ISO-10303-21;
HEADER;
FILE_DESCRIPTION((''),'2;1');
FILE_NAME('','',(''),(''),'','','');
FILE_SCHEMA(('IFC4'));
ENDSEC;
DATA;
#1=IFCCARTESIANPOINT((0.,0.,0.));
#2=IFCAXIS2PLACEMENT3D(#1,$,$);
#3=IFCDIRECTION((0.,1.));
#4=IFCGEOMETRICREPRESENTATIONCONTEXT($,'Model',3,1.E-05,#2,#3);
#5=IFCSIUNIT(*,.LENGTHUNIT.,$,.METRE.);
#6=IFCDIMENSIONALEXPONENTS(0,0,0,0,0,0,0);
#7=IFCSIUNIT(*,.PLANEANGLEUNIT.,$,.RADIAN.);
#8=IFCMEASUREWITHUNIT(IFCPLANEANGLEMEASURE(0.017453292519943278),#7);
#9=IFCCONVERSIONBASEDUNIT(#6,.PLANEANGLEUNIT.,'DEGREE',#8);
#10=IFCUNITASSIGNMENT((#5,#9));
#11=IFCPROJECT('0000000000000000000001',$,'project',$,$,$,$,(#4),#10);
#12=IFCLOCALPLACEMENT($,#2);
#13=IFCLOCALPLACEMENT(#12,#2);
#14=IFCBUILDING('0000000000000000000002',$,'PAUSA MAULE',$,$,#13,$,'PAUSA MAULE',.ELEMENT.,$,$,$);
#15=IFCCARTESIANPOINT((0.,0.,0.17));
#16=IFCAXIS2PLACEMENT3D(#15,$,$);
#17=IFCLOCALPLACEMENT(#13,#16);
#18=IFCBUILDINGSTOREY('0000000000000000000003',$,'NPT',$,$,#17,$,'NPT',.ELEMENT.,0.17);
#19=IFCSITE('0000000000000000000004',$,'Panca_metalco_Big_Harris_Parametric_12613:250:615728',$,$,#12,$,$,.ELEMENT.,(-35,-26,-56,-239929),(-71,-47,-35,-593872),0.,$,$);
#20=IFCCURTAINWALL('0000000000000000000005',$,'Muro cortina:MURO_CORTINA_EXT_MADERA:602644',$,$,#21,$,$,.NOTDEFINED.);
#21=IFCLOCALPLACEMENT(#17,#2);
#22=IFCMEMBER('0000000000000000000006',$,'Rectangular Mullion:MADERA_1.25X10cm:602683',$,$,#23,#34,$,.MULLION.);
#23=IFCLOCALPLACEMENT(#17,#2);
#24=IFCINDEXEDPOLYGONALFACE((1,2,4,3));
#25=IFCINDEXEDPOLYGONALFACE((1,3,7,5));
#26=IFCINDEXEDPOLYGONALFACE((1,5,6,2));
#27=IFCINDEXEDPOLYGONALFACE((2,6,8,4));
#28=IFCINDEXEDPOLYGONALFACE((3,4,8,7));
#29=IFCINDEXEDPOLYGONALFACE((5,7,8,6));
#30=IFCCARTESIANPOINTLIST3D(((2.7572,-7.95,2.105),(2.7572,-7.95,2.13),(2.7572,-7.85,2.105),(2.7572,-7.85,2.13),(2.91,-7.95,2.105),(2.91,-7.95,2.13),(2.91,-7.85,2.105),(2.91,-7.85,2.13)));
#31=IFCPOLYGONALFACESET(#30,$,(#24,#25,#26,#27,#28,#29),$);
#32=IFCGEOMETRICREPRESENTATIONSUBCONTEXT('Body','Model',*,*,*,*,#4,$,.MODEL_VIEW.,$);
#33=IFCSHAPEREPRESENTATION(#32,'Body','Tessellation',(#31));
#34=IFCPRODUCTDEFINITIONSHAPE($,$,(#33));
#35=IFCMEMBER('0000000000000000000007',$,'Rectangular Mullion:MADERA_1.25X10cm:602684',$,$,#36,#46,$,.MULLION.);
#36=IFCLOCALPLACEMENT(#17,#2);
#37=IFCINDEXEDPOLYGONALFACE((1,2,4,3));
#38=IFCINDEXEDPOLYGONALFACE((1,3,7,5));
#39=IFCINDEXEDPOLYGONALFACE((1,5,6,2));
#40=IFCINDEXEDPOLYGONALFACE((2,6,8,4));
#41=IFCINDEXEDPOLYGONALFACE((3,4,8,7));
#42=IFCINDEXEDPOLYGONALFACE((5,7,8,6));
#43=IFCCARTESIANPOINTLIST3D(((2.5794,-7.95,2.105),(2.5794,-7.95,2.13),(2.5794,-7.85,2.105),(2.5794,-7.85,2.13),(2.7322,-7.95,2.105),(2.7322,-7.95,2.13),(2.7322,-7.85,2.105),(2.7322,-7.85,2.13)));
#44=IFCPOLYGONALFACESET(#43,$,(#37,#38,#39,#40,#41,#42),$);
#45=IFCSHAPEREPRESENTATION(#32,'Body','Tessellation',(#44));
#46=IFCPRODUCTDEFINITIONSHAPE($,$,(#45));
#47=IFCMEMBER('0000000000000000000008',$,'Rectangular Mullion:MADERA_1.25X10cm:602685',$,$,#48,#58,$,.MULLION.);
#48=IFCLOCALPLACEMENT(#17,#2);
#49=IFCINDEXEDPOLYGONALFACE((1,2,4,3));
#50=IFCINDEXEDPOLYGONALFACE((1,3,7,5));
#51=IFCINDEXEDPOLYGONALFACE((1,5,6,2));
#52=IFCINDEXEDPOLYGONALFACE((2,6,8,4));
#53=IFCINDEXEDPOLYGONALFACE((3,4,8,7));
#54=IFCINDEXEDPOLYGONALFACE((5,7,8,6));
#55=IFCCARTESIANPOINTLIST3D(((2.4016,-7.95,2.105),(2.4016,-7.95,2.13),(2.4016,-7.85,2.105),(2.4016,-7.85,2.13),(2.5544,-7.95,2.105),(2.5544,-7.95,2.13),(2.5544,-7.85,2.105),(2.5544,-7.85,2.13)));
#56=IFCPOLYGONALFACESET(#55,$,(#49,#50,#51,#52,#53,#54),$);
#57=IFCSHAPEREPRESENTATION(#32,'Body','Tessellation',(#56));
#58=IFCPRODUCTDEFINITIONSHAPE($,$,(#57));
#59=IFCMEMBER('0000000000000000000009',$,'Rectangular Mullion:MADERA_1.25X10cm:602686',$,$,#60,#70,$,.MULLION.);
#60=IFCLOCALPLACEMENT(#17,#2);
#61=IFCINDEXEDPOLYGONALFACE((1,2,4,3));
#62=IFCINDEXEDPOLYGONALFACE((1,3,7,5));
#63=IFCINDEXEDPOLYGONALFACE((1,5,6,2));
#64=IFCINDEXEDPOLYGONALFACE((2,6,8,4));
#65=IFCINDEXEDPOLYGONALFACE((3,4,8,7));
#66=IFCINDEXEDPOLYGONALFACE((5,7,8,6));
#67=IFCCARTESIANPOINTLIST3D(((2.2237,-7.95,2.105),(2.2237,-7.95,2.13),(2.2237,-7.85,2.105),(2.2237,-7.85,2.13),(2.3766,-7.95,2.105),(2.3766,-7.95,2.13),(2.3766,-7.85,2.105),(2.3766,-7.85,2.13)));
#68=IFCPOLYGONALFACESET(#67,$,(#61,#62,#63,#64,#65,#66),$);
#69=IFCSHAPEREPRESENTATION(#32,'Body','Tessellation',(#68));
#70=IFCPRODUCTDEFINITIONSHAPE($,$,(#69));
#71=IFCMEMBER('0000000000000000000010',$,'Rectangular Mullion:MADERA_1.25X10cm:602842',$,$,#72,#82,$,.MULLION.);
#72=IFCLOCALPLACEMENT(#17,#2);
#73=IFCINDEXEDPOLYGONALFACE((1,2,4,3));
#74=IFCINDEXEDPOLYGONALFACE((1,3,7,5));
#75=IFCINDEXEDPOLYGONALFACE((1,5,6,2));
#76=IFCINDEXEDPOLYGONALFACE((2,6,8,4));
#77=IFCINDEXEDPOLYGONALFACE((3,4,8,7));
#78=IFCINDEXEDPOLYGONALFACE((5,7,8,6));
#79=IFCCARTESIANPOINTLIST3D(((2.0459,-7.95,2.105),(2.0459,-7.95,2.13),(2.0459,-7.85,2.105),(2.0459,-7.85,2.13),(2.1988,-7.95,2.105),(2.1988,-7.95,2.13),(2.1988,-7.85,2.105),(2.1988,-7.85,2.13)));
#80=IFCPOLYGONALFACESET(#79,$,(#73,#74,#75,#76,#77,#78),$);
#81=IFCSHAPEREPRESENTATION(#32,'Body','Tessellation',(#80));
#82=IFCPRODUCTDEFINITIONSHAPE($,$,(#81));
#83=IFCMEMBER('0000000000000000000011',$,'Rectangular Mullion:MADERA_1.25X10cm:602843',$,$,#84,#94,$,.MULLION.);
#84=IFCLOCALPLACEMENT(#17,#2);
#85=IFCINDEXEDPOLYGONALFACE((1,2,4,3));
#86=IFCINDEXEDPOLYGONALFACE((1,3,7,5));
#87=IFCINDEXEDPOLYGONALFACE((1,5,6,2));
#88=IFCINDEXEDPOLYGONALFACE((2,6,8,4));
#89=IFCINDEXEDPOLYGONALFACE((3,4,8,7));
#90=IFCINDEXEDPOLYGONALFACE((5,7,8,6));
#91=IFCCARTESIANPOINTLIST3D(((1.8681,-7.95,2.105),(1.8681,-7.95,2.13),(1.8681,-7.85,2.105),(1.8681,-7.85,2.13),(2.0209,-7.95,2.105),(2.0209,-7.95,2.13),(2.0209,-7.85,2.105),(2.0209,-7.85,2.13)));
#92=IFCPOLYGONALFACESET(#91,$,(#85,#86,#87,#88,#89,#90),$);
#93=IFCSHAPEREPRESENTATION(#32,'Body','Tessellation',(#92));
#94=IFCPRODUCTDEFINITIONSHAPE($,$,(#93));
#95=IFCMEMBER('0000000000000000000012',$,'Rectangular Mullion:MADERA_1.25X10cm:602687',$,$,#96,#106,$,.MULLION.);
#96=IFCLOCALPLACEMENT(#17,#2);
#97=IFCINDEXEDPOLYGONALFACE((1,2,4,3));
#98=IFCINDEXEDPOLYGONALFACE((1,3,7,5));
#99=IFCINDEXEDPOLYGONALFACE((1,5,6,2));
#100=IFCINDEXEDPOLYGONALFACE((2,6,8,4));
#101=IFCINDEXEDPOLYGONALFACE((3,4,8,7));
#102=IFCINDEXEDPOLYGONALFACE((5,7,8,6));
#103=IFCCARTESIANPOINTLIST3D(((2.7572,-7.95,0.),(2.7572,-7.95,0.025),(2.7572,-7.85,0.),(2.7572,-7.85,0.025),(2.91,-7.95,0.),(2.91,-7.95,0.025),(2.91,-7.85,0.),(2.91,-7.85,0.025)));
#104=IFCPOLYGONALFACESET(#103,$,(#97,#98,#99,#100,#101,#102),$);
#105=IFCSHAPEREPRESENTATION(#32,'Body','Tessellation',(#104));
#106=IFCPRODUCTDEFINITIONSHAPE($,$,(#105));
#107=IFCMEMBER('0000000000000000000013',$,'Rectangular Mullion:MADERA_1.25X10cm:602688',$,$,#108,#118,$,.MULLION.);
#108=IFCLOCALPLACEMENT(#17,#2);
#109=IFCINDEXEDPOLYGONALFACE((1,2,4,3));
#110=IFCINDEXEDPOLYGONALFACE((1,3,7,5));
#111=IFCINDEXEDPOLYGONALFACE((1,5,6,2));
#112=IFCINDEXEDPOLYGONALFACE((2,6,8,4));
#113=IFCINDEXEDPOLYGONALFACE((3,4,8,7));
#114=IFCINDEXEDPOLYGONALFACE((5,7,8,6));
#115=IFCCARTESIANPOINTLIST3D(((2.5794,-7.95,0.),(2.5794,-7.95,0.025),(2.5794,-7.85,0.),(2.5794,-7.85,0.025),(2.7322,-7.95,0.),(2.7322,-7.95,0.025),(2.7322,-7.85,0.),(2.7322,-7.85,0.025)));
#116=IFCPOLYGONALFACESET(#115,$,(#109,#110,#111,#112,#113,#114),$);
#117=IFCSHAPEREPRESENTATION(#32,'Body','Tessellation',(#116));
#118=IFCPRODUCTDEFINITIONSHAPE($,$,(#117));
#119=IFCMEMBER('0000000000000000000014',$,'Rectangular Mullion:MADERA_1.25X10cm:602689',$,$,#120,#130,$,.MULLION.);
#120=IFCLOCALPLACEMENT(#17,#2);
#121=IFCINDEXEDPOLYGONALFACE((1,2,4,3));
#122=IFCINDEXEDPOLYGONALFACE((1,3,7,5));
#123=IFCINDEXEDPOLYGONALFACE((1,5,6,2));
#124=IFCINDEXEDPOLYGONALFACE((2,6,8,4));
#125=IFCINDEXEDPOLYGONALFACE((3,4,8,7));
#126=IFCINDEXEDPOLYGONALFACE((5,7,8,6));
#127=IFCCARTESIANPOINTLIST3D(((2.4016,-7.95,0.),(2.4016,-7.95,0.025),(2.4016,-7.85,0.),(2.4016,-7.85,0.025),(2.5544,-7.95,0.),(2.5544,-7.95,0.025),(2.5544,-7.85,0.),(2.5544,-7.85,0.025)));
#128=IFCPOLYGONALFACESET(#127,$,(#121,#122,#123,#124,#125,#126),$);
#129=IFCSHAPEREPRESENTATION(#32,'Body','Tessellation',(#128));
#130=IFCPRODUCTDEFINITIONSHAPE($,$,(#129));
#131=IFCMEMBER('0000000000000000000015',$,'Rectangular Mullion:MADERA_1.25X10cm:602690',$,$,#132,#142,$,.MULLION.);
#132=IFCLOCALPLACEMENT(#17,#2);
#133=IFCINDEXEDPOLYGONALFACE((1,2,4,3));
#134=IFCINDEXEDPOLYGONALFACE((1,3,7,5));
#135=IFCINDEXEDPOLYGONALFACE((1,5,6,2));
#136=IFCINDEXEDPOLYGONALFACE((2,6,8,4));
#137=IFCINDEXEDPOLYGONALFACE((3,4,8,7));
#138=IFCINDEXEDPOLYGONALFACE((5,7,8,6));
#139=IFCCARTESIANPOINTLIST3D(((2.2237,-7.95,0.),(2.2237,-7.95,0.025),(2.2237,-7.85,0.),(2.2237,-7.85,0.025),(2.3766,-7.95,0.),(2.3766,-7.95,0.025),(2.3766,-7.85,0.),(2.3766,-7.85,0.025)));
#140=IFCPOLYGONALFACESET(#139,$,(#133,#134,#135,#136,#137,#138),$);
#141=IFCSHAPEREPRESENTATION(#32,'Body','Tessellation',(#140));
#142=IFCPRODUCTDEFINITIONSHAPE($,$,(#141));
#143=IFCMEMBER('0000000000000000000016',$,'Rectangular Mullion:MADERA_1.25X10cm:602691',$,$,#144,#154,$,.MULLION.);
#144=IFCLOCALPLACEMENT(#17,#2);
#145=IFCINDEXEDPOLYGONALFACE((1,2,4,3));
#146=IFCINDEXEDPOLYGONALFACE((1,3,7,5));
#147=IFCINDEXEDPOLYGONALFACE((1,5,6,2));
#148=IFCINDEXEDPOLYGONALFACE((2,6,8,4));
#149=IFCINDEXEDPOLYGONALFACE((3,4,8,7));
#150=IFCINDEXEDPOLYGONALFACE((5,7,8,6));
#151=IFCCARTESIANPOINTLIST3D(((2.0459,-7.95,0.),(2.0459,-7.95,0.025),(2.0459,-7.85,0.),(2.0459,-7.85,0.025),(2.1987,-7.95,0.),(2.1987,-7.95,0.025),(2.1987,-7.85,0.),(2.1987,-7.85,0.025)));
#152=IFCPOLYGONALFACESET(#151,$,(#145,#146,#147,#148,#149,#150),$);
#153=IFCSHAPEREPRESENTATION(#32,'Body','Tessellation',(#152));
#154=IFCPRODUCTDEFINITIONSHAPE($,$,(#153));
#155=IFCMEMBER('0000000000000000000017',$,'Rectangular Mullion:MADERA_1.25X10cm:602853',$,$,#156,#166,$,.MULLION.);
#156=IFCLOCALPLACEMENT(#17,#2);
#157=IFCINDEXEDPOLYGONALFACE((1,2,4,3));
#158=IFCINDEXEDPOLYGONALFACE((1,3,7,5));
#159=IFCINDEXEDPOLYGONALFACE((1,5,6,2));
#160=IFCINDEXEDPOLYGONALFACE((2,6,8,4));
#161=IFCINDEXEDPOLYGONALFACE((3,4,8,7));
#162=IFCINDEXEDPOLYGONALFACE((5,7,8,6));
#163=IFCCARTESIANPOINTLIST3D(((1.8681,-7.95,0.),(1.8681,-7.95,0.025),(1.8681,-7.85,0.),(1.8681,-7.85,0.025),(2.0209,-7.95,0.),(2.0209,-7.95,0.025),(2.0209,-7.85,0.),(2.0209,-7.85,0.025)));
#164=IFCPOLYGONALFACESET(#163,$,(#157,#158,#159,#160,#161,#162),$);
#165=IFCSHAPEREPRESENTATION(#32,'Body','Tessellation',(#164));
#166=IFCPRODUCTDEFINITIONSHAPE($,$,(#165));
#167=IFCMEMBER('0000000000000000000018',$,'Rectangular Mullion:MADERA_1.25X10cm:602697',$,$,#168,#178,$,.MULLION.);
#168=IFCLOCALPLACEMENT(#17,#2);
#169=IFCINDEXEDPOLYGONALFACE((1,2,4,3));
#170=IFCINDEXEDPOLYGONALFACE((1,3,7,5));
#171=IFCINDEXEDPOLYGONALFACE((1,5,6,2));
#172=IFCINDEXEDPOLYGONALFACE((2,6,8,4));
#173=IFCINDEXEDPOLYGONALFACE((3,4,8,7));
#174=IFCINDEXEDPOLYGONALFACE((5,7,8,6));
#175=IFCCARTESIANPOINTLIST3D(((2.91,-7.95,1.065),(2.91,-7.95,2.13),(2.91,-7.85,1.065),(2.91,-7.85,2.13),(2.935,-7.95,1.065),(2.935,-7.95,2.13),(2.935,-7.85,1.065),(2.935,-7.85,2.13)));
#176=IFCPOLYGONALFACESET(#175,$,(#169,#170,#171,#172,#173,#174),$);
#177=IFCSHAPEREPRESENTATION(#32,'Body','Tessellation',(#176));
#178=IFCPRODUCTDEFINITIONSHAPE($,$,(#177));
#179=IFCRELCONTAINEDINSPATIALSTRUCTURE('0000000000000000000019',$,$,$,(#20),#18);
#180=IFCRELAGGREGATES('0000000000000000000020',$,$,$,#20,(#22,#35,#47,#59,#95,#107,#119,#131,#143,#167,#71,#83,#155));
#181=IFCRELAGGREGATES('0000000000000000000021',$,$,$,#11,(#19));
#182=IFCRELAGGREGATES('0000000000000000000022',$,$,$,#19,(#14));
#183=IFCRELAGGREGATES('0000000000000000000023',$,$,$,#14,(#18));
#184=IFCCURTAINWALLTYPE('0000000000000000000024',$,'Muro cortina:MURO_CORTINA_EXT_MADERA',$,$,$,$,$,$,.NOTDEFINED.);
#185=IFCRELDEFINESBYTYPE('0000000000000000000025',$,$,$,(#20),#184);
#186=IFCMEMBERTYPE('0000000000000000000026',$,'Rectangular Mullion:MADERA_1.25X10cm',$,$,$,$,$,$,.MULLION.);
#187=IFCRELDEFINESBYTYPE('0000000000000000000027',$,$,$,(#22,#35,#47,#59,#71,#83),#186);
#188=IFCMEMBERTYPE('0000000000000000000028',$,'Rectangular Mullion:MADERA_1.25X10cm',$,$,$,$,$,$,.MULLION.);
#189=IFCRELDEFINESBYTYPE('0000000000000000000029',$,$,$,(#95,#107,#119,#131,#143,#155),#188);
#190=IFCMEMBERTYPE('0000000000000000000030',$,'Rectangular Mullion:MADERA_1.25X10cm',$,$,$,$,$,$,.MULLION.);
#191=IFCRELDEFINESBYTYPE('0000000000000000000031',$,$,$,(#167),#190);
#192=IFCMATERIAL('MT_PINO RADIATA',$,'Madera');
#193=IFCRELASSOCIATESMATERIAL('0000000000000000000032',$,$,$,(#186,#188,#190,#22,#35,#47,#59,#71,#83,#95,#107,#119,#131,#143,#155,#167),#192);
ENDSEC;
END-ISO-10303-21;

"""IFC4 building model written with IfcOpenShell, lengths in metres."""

from ifc_helpers import new_model, entity, si_unit, converted_unit, direction, frame, frame_2d, origin, place, context, subcontext, project, spatial, rectangle, extrude, source, transform, mapped, material, material_profile, profile_set, profile_usage, type_object, type_shapes, element, aggregate, save


model = new_model("IFC4")

# Units and contexts
model_context = context("Model", 3, precision=1e-05, world=origin(), true_north=direction((0.0, 1.0)))
body_context = subcontext(model_context, "Body", "Model", "MODEL_VIEW")
ifc_project = project(units=[si_unit("LENGTHUNIT", "METRE"), converted_unit("PLANEANGLEUNIT", "DEGREE", entity("IfcPlaneAngleMeasure", 0.017453292519943278), si_unit("PLANEANGLEUNIT", "RADIAN"), dimensions=[0, 0, 0, 0, 0, 0, 0])], contexts=[model_context])

# Site, building, storey
site_placement = place(None, origin())
site = spatial("IfcSite", under=ifc_project, at=site_placement, Name="Panca_metalco_Big_Harris_Parametric_12613:250:615728", CompositionType="ELEMENT", RefLatitude=(-35, -26, -56, -239929), RefLongitude=(-71, -47, -35, -593872), RefElevation=0.0)
building_placement = place(site_placement, origin())
building = spatial("IfcBuilding", under=site, at=building_placement, Name="PAUSA MAULE", LongName="PAUSA MAULE", CompositionType="ELEMENT")
storey_placement = place(building_placement, frame((0.0, 0.0, 0.17)))
storey = spatial("IfcBuildingStorey", under=building, at=storey_placement, Name="NPT", LongName="NPT", CompositionType="ELEMENT", Elevation=0.17)

# Curtain wall, members
curtain_wall_type = type_object("IfcCurtainWallType", Name="Muro cortina:MURO_CORTINA_EXT_MADERA", PredefinedType="NOTDEFINED")
curtain_wall_placement = place(storey_placement, frame((0.0, 0.0, -0.17)))
curtain_wall = element("IfcCurtainWall", 1, at=curtain_wall_placement, inside=storey, type_object=curtain_wall_type, Name="Muro cortina:MURO_CORTINA_EXT_MADERA:602644", PredefinedType="NOTDEFINED")
ifc_material = material(Name="MT_PINO RADIATA", Category="Madera")
ifc_material_profile = material_profile(ifc_material, rectangle(XDim=0.025, YDim=0.1, at=frame_2d((0.0, 0.0), x_axis=(1.0, 0.0))), Name="MADERA_1.25X10cm")
ifc_profile_set = profile_set([ifc_material_profile], Name="MADERA_1.25X10cm")
ifc_profile_usage = profile_usage(ifc_profile_set)
member_type_1 = type_object("IfcMemberType", Name="Rectangular Mullion:MADERA_1.25X10cm", PredefinedType="MULLION", material=ifc_profile_set)
shared_shape_1 = source(origin(), body_context, "Body", "SweptSolid", [
    extrude(rectangle(XDim=0.025, YDim=0.1, at=frame_2d((0.0, 0.0), x_axis=(1.0, 0.0))), frame((-0.0125, 0.0, -0.1528), z_axis=(0.0, 0.0, 1.0), x_axis=(-1.0, 0.0, 0.0)), (0.0, 0.0, 1.0), 0.1528),
])
type_shapes(member_type_1, [shared_shape_1])
member_1_placement = place(curtain_wall_placement, frame((2.7572, -7.9, 2.3), z_axis=(-1.0, 0.0, 0.0), x_axis=(0.0, 0.0, 1.0)))
member_1 = element("IfcMember", 2, at=member_1_placement, type_object=member_type_1, material=ifc_profile_usage, Name="Rectangular Mullion:MADERA_1.25X10cm:602683", PredefinedType="MULLION", context=body_context, shape_type="MappedRepresentation", body=[
    mapped(shared_shape_1, transform((0.0, 0.0, 0.0), scale=1.0)),
])
member_2_placement = place(curtain_wall_placement, frame((2.5794, -7.9, 2.3), z_axis=(-1.0, 0.0, 0.0), x_axis=(0.0, 0.0, 1.0)))
member_2 = element("IfcMember", 3, at=member_2_placement, type_object=member_type_1, material=ifc_profile_usage, Name="Rectangular Mullion:MADERA_1.25X10cm:602684", PredefinedType="MULLION", context=body_context, shape_type="MappedRepresentation", body=[
    mapped(shared_shape_1, transform((0.0, 0.0, 0.0), scale=1.0)),
])
member_3_placement = place(curtain_wall_placement, frame((2.4016, -7.9, 2.3), z_axis=(-1.0, 0.0, 0.0), x_axis=(0.0, 0.0, 1.0)))
member_3 = element("IfcMember", 4, at=member_3_placement, type_object=member_type_1, material=ifc_profile_usage, Name="Rectangular Mullion:MADERA_1.25X10cm:602685", PredefinedType="MULLION", context=body_context, shape_type="MappedRepresentation", body=[
    mapped(shared_shape_1, transform((0.0, 0.0, 0.0), scale=1.0)),
])
member_4_placement = place(curtain_wall_placement, frame((2.2237, -7.9, 2.3), z_axis=(-1.0, 0.0, 0.0), x_axis=(0.0, 0.0, 1.0)))
member_4 = element("IfcMember", 5, at=member_4_placement, type_object=member_type_1, material=ifc_profile_usage, Name="Rectangular Mullion:MADERA_1.25X10cm:602686", PredefinedType="MULLION", context=body_context, shape_type="MappedRepresentation", body=[
    mapped(shared_shape_1, transform((0.0, 0.0, 0.0), scale=1.0)),
])
member_5_placement = place(curtain_wall_placement, frame((2.0459, -7.9, 2.3), z_axis=(-1.0, 0.0, 0.0), x_axis=(0.0, 0.0, 1.0)))
member_5 = element("IfcMember", 6, at=member_5_placement, type_object=member_type_1, material=ifc_profile_usage, Name="Rectangular Mullion:MADERA_1.25X10cm:602842", PredefinedType="MULLION", context=body_context, shape_type="MappedRepresentation", body=[
    mapped(shared_shape_1, transform((0.0, 0.0, 0.0), scale=1.0)),
])
member_6_placement = place(curtain_wall_placement, frame((1.8681, -7.9, 2.3), z_axis=(-1.0, 0.0, 0.0), x_axis=(0.0, 0.0, 1.0)))
member_6 = element("IfcMember", 7, at=member_6_placement, type_object=member_type_1, material=ifc_profile_usage, Name="Rectangular Mullion:MADERA_1.25X10cm:602843", PredefinedType="MULLION", context=body_context, shape_type="MappedRepresentation", body=[
    mapped(shared_shape_1, transform((0.0, 0.0, 0.0), scale=1.0)),
])
member_type_2 = type_object("IfcMemberType", Name="Rectangular Mullion:MADERA_1.25X10cm", PredefinedType="MULLION", material=ifc_profile_set)
shared_shape_2 = source(origin(), body_context, "Body", "SweptSolid", [
    extrude(rectangle(XDim=0.025, YDim=0.1, at=frame_2d((0.0, 0.0), x_axis=(1.0, 0.0))), frame((-0.0125, 0.0, -0.1528), z_axis=(0.0, 0.0, 1.0), x_axis=(-1.0, 0.0, 0.0)), (0.0, 0.0, 1.0), 0.1528),
])
type_shapes(member_type_2, [shared_shape_2])
member_7_placement = place(curtain_wall_placement, frame((2.91, -7.9, 0.17), z_axis=(1.0, 0.0, 0.0), x_axis=(0.0, 0.0, -1.0)))
member_7 = element("IfcMember", 8, at=member_7_placement, type_object=member_type_2, material=ifc_profile_usage, Name="Rectangular Mullion:MADERA_1.25X10cm:602687", PredefinedType="MULLION", context=body_context, shape_type="MappedRepresentation", body=[
    mapped(shared_shape_2, transform((0.0, 0.0, 0.0), scale=1.0)),
])
member_8_placement = place(curtain_wall_placement, frame((2.7322, -7.9, 0.17), z_axis=(1.0, 0.0, 0.0), x_axis=(0.0, 0.0, -1.0)))
member_8 = element("IfcMember", 9, at=member_8_placement, type_object=member_type_2, material=ifc_profile_usage, Name="Rectangular Mullion:MADERA_1.25X10cm:602688", PredefinedType="MULLION", context=body_context, shape_type="MappedRepresentation", body=[
    mapped(shared_shape_2, transform((0.0, 0.0, 0.0), scale=1.0)),
])
member_9_placement = place(curtain_wall_placement, frame((2.5544, -7.9, 0.17), z_axis=(1.0, 0.0, 0.0), x_axis=(0.0, 0.0, -1.0)))
member_9 = element("IfcMember", 10, at=member_9_placement, type_object=member_type_2, material=ifc_profile_usage, Name="Rectangular Mullion:MADERA_1.25X10cm:602689", PredefinedType="MULLION", context=body_context, shape_type="MappedRepresentation", body=[
    mapped(shared_shape_2, transform((0.0, 0.0, 0.0), scale=1.0)),
])
member_10_placement = place(curtain_wall_placement, frame((2.3766, -7.9, 0.17), z_axis=(1.0, 0.0, 0.0), x_axis=(0.0, 0.0, -1.0)))
member_10 = element("IfcMember", 11, at=member_10_placement, type_object=member_type_2, material=ifc_profile_usage, Name="Rectangular Mullion:MADERA_1.25X10cm:602690", PredefinedType="MULLION", context=body_context, shape_type="MappedRepresentation", body=[
    mapped(shared_shape_2, transform((0.0, 0.0, 0.0), scale=1.0)),
])
member_11_placement = place(curtain_wall_placement, frame((2.1987, -7.9, 0.17), z_axis=(1.0, 0.0, 0.0), x_axis=(0.0, 0.0, -1.0)))
member_11 = element("IfcMember", 12, at=member_11_placement, type_object=member_type_2, material=ifc_profile_usage, Name="Rectangular Mullion:MADERA_1.25X10cm:602691", PredefinedType="MULLION", context=body_context, shape_type="MappedRepresentation", body=[
    mapped(shared_shape_2, transform((0.0, 0.0, 0.0), scale=1.0)),
])
member_12_placement = place(curtain_wall_placement, frame((2.0209, -7.9, 0.17), z_axis=(1.0, 0.0, 0.0), x_axis=(0.0, 0.0, -1.0)))
member_12 = element("IfcMember", 13, at=member_12_placement, type_object=member_type_2, material=ifc_profile_usage, Name="Rectangular Mullion:MADERA_1.25X10cm:602853", PredefinedType="MULLION", context=body_context, shape_type="MappedRepresentation", body=[
    mapped(shared_shape_2, transform((0.0, 0.0, 0.0), scale=1.0)),
])
member_type_3 = type_object("IfcMemberType", Name="Rectangular Mullion:MADERA_1.25X10cm", PredefinedType="MULLION", material=ifc_profile_set)
shared_shape_3 = source(origin(), body_context, "Body", "SweptSolid", [
    extrude(rectangle(XDim=0.025, YDim=0.1, at=frame_2d((0.0, 0.0), x_axis=(1.0, 0.0))), frame((-0.0125, 0.0, -1.065), z_axis=(0.0, 0.0, 1.0), x_axis=(-1.0, 0.0, 0.0)), (0.0, 0.0, 1.0), 1.065),
])
type_shapes(member_type_3, [shared_shape_3])
member_13_placement = place(curtain_wall_placement, frame((2.935, -7.9, 2.3)))
member_13 = element("IfcMember", 14, at=member_13_placement, type_object=member_type_3, material=ifc_profile_usage, Name="Rectangular Mullion:MADERA_1.25X10cm:602697", PredefinedType="MULLION", context=body_context, shape_type="MappedRepresentation", body=[
    mapped(shared_shape_3, transform((0.0, 0.0, 0.0), scale=1.0)),
])
aggregate(curtain_wall, [member_1, member_2, member_3, member_4, member_7, member_8, member_9, member_10, member_11, member_13, member_5, member_6, member_12])

save(model, "model.ifc")
